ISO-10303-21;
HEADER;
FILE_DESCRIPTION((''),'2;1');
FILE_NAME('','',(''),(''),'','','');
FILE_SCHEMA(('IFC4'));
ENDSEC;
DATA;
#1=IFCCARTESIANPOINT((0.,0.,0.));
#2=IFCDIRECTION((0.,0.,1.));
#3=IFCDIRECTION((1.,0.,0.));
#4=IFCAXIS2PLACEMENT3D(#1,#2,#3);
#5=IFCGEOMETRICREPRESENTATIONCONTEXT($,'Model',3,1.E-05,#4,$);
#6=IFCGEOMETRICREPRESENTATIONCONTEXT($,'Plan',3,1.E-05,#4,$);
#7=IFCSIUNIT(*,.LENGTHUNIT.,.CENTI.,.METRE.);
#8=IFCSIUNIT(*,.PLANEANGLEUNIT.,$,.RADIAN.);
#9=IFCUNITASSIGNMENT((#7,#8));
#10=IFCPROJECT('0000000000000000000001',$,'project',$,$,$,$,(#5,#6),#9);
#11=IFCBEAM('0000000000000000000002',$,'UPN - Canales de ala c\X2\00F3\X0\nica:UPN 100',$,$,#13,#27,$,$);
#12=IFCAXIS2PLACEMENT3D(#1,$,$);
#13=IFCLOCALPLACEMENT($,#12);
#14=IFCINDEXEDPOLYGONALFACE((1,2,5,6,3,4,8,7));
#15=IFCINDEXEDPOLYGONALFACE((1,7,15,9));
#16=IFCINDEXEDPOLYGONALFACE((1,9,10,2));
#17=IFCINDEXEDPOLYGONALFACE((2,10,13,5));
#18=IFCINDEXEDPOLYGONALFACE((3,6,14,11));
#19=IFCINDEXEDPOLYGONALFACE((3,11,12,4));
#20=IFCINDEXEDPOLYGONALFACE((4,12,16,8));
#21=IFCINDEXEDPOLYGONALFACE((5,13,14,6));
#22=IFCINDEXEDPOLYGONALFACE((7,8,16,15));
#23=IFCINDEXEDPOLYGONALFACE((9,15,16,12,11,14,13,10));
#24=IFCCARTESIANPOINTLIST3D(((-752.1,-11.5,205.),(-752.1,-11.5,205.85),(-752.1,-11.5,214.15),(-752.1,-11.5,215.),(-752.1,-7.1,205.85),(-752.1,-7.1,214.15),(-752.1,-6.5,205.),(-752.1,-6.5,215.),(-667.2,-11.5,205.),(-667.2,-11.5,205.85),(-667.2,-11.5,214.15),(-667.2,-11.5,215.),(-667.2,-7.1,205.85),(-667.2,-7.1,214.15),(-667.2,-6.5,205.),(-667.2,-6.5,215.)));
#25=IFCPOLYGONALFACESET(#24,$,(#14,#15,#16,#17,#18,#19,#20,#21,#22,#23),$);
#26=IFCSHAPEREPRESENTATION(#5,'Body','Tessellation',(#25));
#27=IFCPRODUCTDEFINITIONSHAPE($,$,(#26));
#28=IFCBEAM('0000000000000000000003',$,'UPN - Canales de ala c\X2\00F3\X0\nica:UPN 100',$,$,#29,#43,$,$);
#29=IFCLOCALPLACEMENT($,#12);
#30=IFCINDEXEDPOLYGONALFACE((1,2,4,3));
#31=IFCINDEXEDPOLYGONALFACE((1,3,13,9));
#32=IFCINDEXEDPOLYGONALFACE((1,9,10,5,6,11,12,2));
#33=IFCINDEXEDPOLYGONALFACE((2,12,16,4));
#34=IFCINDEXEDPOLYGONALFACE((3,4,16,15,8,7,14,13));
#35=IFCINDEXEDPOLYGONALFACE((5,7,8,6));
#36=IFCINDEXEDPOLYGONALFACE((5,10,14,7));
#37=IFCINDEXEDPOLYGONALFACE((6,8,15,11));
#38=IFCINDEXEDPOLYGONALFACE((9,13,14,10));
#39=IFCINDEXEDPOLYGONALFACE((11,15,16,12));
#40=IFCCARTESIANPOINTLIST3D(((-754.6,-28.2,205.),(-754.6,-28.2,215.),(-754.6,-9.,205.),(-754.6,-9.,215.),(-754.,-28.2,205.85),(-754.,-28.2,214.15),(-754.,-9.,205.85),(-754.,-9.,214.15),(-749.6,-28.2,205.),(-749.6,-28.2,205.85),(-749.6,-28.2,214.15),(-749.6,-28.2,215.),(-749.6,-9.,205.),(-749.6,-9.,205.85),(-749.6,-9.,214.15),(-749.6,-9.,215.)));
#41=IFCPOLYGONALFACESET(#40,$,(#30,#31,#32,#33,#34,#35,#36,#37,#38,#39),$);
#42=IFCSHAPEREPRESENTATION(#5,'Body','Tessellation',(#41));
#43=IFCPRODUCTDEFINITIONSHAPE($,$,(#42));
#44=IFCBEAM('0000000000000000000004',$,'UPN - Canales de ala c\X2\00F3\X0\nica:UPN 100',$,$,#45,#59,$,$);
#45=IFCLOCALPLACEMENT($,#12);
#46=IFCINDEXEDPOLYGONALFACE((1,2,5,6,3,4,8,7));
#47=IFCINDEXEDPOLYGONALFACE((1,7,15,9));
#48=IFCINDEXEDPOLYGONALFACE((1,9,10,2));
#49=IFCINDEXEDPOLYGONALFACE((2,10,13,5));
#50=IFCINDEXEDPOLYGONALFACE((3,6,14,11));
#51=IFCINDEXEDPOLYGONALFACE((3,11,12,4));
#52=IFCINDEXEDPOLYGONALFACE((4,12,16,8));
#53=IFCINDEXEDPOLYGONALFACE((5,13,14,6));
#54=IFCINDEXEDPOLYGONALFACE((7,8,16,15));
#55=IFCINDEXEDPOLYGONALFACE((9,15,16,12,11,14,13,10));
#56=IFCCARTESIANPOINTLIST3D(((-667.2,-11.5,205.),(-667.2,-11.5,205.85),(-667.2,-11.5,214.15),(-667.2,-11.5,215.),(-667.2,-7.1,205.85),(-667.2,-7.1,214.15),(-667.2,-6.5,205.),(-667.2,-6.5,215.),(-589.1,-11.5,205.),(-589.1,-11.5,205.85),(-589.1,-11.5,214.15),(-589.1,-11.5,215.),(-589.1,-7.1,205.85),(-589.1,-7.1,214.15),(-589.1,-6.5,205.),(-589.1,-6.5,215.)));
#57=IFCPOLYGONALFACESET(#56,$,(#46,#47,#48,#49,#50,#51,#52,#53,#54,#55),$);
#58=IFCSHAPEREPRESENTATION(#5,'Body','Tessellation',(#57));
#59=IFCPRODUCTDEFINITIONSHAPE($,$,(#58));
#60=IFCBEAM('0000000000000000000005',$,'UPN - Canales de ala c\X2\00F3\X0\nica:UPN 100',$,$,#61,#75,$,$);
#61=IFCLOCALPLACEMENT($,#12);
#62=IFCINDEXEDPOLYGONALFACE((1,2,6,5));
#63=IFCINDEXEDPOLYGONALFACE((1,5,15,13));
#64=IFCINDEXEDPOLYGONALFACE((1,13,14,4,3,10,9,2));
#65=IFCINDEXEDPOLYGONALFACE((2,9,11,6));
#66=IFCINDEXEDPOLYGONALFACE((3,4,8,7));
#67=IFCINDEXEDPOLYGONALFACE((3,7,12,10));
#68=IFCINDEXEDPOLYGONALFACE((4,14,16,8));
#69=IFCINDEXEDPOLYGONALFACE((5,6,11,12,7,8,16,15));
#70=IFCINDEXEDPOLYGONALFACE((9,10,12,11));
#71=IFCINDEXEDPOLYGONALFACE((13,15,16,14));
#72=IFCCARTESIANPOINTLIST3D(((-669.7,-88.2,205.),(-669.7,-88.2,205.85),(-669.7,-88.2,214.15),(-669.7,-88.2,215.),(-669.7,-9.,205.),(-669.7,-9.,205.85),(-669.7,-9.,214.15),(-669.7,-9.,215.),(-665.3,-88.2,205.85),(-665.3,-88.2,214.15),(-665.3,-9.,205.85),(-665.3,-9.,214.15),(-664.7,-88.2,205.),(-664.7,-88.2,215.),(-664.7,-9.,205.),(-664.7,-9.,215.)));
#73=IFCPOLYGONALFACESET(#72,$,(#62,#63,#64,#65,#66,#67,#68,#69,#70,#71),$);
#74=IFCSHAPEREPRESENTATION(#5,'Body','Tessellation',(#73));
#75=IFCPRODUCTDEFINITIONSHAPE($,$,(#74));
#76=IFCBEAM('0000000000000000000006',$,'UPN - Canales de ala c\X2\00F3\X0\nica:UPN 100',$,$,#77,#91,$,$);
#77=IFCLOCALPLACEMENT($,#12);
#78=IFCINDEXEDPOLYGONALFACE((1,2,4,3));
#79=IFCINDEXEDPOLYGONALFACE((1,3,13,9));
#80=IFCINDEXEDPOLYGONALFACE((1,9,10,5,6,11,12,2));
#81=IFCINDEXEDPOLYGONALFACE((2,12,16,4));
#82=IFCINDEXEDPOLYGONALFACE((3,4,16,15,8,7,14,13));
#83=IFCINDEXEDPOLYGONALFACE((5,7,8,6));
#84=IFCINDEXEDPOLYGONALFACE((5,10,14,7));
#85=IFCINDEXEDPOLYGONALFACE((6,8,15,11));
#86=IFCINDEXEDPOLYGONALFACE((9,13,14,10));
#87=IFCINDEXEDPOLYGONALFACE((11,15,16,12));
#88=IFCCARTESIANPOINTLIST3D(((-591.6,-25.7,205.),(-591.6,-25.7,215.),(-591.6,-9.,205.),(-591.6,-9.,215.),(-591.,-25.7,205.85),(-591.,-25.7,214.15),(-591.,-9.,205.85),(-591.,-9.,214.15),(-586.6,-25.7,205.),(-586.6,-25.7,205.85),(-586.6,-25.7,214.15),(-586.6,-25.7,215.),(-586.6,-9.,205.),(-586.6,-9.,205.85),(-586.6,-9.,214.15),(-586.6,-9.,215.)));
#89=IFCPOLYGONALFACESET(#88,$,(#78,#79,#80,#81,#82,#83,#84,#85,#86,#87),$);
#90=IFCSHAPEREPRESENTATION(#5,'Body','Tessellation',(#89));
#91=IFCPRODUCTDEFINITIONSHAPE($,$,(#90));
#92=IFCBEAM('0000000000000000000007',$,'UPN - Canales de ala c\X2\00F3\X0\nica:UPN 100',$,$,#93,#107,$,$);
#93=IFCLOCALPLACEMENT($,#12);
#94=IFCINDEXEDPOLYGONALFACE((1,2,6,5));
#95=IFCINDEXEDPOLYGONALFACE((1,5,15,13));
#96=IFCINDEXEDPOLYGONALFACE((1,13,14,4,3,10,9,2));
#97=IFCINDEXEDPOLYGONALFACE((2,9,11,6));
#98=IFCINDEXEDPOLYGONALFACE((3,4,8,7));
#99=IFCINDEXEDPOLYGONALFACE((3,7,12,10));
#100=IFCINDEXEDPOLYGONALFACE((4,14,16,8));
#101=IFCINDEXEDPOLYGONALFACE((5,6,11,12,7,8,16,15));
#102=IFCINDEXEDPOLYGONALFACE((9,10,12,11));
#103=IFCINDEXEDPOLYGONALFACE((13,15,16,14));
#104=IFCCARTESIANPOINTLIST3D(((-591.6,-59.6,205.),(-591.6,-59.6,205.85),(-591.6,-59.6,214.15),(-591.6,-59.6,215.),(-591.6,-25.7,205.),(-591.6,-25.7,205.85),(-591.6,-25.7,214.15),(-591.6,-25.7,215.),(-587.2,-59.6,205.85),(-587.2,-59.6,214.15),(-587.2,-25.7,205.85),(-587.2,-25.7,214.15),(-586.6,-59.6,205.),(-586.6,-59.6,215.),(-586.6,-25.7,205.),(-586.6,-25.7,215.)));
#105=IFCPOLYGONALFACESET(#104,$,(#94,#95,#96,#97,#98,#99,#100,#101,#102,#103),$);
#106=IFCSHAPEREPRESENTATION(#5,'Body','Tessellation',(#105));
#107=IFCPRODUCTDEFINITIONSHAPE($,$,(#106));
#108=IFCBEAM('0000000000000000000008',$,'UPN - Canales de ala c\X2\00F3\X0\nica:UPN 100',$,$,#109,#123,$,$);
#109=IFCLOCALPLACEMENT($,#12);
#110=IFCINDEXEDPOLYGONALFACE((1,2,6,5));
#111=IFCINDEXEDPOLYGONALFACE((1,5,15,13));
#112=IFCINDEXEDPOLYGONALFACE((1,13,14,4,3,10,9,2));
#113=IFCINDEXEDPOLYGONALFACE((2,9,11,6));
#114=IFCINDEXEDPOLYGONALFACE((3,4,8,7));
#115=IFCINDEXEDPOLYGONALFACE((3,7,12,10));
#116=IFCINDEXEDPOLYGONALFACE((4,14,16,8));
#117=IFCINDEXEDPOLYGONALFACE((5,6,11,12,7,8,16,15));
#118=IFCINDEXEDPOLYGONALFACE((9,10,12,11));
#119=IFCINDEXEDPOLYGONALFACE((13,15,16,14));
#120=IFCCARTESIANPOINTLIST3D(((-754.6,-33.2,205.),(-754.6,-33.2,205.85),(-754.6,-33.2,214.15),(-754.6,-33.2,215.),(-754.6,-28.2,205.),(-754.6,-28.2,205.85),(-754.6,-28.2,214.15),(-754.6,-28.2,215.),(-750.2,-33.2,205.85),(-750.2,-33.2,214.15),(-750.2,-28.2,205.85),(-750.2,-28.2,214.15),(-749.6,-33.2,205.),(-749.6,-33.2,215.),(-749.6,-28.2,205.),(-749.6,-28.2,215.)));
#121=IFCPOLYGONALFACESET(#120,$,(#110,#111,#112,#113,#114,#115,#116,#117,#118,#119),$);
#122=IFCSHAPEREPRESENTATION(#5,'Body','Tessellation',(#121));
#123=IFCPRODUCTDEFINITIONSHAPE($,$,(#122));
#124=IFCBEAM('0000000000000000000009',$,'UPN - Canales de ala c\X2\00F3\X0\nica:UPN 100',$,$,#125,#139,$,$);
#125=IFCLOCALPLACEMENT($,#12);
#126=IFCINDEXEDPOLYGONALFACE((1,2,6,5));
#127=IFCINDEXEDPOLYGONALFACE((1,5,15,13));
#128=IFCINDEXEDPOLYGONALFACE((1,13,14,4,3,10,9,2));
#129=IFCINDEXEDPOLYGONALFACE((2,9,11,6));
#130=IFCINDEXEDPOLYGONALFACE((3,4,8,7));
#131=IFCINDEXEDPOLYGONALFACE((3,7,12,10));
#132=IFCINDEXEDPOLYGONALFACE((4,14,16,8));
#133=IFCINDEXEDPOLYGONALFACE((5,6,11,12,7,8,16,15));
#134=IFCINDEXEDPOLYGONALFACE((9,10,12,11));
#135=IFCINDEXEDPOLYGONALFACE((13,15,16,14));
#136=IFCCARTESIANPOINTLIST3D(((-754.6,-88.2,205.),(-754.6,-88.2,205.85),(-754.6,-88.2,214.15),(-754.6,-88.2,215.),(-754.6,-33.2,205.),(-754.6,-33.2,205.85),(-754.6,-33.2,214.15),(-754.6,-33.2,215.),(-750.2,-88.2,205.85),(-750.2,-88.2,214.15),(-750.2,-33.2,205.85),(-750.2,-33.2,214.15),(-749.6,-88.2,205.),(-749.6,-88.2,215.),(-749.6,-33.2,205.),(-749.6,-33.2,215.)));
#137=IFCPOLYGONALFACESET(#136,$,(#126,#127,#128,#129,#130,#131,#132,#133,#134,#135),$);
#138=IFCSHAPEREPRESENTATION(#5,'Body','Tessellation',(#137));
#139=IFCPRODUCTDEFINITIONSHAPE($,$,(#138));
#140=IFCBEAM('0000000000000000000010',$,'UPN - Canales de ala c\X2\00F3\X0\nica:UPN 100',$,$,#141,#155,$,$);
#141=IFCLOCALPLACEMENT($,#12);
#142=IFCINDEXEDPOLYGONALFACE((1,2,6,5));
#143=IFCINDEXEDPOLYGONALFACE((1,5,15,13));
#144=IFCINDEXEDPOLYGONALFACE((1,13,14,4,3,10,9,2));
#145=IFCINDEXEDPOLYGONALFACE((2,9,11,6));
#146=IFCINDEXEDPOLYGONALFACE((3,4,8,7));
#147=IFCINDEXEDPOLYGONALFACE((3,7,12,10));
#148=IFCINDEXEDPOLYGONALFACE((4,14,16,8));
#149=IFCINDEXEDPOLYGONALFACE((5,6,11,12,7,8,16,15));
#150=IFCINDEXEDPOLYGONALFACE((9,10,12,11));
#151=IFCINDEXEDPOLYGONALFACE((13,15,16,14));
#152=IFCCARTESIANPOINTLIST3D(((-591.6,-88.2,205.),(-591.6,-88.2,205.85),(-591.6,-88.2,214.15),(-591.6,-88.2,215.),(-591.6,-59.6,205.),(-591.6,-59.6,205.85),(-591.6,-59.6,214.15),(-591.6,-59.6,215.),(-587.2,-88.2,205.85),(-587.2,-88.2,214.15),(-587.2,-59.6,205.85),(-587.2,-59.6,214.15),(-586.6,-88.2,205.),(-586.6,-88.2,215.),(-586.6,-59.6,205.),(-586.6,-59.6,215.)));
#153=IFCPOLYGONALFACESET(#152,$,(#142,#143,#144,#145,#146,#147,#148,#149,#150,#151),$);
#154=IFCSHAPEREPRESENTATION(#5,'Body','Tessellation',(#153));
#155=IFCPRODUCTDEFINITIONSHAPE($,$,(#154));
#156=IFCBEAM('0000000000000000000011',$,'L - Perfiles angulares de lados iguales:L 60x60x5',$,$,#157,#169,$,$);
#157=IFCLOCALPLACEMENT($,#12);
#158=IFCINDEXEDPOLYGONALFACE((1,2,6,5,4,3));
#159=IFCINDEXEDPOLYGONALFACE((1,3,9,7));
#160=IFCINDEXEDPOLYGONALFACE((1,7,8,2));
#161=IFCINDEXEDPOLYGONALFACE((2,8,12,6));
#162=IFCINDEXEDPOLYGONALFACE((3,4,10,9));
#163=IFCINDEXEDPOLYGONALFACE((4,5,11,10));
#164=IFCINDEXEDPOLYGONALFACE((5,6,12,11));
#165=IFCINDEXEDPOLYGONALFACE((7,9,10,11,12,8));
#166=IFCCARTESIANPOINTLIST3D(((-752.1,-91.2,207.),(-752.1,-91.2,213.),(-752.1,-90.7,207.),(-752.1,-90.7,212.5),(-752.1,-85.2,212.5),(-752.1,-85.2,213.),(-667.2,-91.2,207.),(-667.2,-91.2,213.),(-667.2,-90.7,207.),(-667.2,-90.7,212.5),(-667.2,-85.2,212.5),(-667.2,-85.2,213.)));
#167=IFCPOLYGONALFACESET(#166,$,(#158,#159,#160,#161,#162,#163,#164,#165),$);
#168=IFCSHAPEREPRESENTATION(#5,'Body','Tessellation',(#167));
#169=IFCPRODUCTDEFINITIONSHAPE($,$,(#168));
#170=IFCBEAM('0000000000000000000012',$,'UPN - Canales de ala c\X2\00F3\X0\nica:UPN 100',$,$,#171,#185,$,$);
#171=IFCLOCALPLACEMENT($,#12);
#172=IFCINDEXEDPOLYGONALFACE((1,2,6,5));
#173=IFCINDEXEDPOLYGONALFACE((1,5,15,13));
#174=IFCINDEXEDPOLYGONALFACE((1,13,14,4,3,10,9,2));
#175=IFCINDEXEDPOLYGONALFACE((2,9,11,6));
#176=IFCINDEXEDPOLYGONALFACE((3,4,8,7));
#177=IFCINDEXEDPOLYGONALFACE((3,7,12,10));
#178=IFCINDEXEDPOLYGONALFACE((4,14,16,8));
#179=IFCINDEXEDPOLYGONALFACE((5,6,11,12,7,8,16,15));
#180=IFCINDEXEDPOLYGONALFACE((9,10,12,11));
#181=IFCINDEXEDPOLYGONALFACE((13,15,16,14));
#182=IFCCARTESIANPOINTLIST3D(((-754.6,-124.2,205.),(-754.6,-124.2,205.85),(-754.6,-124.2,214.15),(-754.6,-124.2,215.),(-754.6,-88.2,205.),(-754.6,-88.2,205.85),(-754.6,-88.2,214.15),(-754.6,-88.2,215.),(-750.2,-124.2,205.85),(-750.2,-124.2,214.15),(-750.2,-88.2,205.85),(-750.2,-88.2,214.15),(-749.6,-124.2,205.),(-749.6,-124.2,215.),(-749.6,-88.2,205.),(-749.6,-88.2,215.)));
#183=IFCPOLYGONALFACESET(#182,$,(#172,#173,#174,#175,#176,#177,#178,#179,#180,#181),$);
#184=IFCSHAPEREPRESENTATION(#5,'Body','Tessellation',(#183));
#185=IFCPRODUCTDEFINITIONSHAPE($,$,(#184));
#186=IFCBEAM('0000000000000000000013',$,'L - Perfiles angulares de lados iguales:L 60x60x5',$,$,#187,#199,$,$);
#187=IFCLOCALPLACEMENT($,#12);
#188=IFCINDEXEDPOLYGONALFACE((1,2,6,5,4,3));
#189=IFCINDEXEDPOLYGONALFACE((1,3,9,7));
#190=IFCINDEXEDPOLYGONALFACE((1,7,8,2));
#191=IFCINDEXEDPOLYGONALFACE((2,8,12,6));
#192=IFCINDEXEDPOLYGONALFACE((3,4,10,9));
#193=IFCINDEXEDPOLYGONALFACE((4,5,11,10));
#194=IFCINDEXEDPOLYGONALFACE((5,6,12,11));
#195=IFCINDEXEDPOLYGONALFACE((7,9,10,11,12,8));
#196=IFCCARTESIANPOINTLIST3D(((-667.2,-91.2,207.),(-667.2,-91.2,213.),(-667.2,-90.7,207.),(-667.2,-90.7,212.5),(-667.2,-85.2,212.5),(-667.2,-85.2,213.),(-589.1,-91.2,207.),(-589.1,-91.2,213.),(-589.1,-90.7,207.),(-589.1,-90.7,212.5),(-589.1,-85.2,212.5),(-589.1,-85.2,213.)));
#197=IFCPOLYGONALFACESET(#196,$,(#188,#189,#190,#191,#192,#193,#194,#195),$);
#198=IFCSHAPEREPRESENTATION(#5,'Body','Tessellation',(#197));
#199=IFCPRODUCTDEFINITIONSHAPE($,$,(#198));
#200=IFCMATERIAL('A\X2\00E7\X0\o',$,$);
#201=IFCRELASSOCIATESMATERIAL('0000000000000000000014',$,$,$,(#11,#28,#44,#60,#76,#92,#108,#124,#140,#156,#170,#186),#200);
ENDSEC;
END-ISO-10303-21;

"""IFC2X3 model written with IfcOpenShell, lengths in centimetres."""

from ifc_helpers import new_model, si_unit, frame, origin_with_axes, origin_2d_with_axis, place, context, project, polyline, u_section, outline, extrude, material, element, save


model = new_model("IFC2X3")

# Units and contexts
model_context = context("Model", 3, precision=1e-05, world=origin_with_axes())
plan_context = context("Plan", 3, precision=1e-05, world=origin_with_axes())
ifc_project = project(units=[si_unit("LENGTHUNIT", "METRE", prefix="CENTI"), si_unit("PLANEANGLEUNIT", "RADIAN")], contexts=[model_context, plan_context])

# Shared definitions
ifc_material = material(Name="Aço")

# Beams
beam_1_placement = place(None, frame((-667.2, -9.0, 210.0), z_axis=(-1.0, 0.0, 0.0), x_axis=(0.0, -1.0, 0.0)))
element("IfcBeam", 1, at=beam_1_placement, material=ifc_material, Name="UPN - Canales de ala cónica:UPN 100", context=model_context, shape_type="SweptSolid", body=[
    extrude(u_section(Depth=10.0, FlangeWidth=5.0, WebThickness=0.6, FlangeThickness=0.85, FilletRadius=0.0, EdgeRadius=0.0, FlangeSlope=0.0, CentreOfGravityInX=0.0, at=origin_2d_with_axis()), origin_with_axes(), (0.0, 0.0, 1.0), 84.9),
])
beam_2_placement = place(None, frame((-752.1, -28.2, 210.0), z_axis=(0.0, 1.0, 0.0), x_axis=(1.0, 0.0, 0.0)))
element("IfcBeam", 2, at=beam_2_placement, material=ifc_material, Name="UPN - Canales de ala cónica:UPN 100", context=model_context, shape_type="SweptSolid", body=[
    extrude(u_section(Depth=10.0, FlangeWidth=5.0, WebThickness=0.6, FlangeThickness=0.85, FilletRadius=0.0, EdgeRadius=0.0, FlangeSlope=0.0, CentreOfGravityInX=0.0, at=origin_2d_with_axis()), origin_with_axes(), (0.0, 0.0, 1.0), 19.2),
])
beam_3_placement = place(None, frame((-589.1, -9.0, 210.0), z_axis=(-1.0, 0.0, 0.0), x_axis=(0.0, -1.0, 0.0)))
element("IfcBeam", 3, at=beam_3_placement, material=ifc_material, Name="UPN - Canales de ala cónica:UPN 100", context=model_context, shape_type="SweptSolid", body=[
    extrude(u_section(Depth=10.0, FlangeWidth=5.0, WebThickness=0.6, FlangeThickness=0.85, FilletRadius=0.0, EdgeRadius=0.0, FlangeSlope=0.0, CentreOfGravityInX=0.0, at=origin_2d_with_axis()), origin_with_axes(), (0.0, 0.0, 1.0), 78.1),
])
beam_4_placement = place(None, frame((-667.2, -88.2, 210.0), z_axis=(0.0, 1.0, 0.0), x_axis=(-1.0, 0.0, 0.0)))
element("IfcBeam", 4, at=beam_4_placement, material=ifc_material, Name="UPN - Canales de ala cónica:UPN 100", context=model_context, shape_type="SweptSolid", body=[
    extrude(u_section(Depth=10.0, FlangeWidth=5.0, WebThickness=0.6, FlangeThickness=0.85, FilletRadius=0.0, EdgeRadius=0.0, FlangeSlope=0.0, CentreOfGravityInX=0.0, at=origin_2d_with_axis()), origin_with_axes(), (0.0, 0.0, 1.0), 79.2),
])
beam_5_placement = place(None, frame((-589.1, -25.7, 210.0), z_axis=(0.0, 1.0, 0.0), x_axis=(1.0, 0.0, 0.0)))
element("IfcBeam", 5, at=beam_5_placement, material=ifc_material, Name="UPN - Canales de ala cónica:UPN 100", context=model_context, shape_type="SweptSolid", body=[
    extrude(u_section(Depth=10.0, FlangeWidth=5.0, WebThickness=0.6, FlangeThickness=0.85, FilletRadius=0.0, EdgeRadius=0.0, FlangeSlope=0.0, CentreOfGravityInX=0.0, at=origin_2d_with_axis()), origin_with_axes(), (0.0, 0.0, 1.0), 16.7),
])
beam_6_placement = place(None, frame((-589.1, -59.6, 210.0), z_axis=(0.0, 1.0, 0.0), x_axis=(-1.0, 0.0, 0.0)))
element("IfcBeam", 6, at=beam_6_placement, material=ifc_material, Name="UPN - Canales de ala cónica:UPN 100", context=model_context, shape_type="SweptSolid", body=[
    extrude(u_section(Depth=10.0, FlangeWidth=5.0, WebThickness=0.6, FlangeThickness=0.85, FilletRadius=0.0, EdgeRadius=0.0, FlangeSlope=0.0, CentreOfGravityInX=0.0, at=origin_2d_with_axis()), origin_with_axes(), (0.0, 0.0, 1.0), 33.9),
])
beam_7_placement = place(None, frame((-752.1, -33.2, 210.0), z_axis=(0.0, 1.0, 0.0), x_axis=(-1.0, 0.0, 0.0)))
element("IfcBeam", 7, at=beam_7_placement, material=ifc_material, Name="UPN - Canales de ala cónica:UPN 100", context=model_context, shape_type="SweptSolid", body=[
    extrude(u_section(Depth=10.0, FlangeWidth=5.0, WebThickness=0.6, FlangeThickness=0.85, FilletRadius=0.0, EdgeRadius=0.0, FlangeSlope=0.0, CentreOfGravityInX=0.0, at=origin_2d_with_axis()), origin_with_axes(), (0.0, 0.0, 1.0), 5.0),
])
beam_8_placement = place(None, frame((-752.1, -88.2, 210.0), z_axis=(0.0, 1.0, 0.0), x_axis=(-1.0, 0.0, 0.0)))
element("IfcBeam", 8, at=beam_8_placement, material=ifc_material, Name="UPN - Canales de ala cónica:UPN 100", context=model_context, shape_type="SweptSolid", body=[
    extrude(u_section(Depth=10.0, FlangeWidth=5.0, WebThickness=0.6, FlangeThickness=0.85, FilletRadius=0.0, EdgeRadius=0.0, FlangeSlope=0.0, CentreOfGravityInX=0.0, at=origin_2d_with_axis()), origin_with_axes(), (0.0, 0.0, 1.0), 55.0),
])
beam_9_placement = place(None, frame((-589.1, -88.2, 210.0), z_axis=(0.0, 1.0, 0.0), x_axis=(-1.0, 0.0, 0.0)))
element("IfcBeam", 9, at=beam_9_placement, material=ifc_material, Name="UPN - Canales de ala cónica:UPN 100", context=model_context, shape_type="SweptSolid", body=[
    extrude(u_section(Depth=10.0, FlangeWidth=5.0, WebThickness=0.6, FlangeThickness=0.85, FilletRadius=0.0, EdgeRadius=0.0, FlangeSlope=0.0, CentreOfGravityInX=0.0, at=origin_2d_with_axis()), origin_with_axes(), (0.0, 0.0, 1.0), 28.6),
])
beam_10_placement = place(None, frame((-667.2, -88.2, 210.0), z_axis=(-1.0, 0.0, 0.0), x_axis=(0.0, 0.0, -1.0)))
element("IfcBeam", 10, at=beam_10_placement, material=ifc_material, Name="L - Perfiles angulares de lados iguales:L 60x60x5", context=model_context, shape_type="SweptSolid", body=[
    extrude(outline(polyline([(-3.0, -3.0), (-2.5, -3.0), (-2.5, 2.5), (3.0, 2.5), (3.0, 3.0), (-3.0, 3.0), (-3.0, -3.0)])), origin_with_axes(), (0.0, 0.0, 1.0), 84.9),
])
beam_11_placement = place(None, frame((-752.1, -124.2, 210.0), z_axis=(0.0, 1.0, 0.0), x_axis=(-1.0, 0.0, 0.0)))
element("IfcBeam", 11, at=beam_11_placement, material=ifc_material, Name="UPN - Canales de ala cónica:UPN 100", context=model_context, shape_type="SweptSolid", body=[
    extrude(u_section(Depth=10.0, FlangeWidth=5.0, WebThickness=0.6, FlangeThickness=0.85, FilletRadius=0.0, EdgeRadius=0.0, FlangeSlope=0.0, CentreOfGravityInX=0.0, at=origin_2d_with_axis()), origin_with_axes(), (0.0, 0.0, 1.0), 36.0),
])
beam_12_placement = place(None, frame((-589.1, -88.2, 210.0), z_axis=(-1.0, 0.0, 0.0), x_axis=(0.0, 0.0, -1.0)))
element("IfcBeam", 12, at=beam_12_placement, material=ifc_material, Name="L - Perfiles angulares de lados iguales:L 60x60x5", context=model_context, shape_type="SweptSolid", body=[
    extrude(outline(polyline([(-3.0, -3.0), (-2.5, -3.0), (-2.5, 2.5), (3.0, 2.5), (3.0, 3.0), (-3.0, 3.0), (-3.0, -3.0)])), origin_with_axes(), (0.0, 0.0, 1.0), 78.1),
])

save(model, "model.ifc")
